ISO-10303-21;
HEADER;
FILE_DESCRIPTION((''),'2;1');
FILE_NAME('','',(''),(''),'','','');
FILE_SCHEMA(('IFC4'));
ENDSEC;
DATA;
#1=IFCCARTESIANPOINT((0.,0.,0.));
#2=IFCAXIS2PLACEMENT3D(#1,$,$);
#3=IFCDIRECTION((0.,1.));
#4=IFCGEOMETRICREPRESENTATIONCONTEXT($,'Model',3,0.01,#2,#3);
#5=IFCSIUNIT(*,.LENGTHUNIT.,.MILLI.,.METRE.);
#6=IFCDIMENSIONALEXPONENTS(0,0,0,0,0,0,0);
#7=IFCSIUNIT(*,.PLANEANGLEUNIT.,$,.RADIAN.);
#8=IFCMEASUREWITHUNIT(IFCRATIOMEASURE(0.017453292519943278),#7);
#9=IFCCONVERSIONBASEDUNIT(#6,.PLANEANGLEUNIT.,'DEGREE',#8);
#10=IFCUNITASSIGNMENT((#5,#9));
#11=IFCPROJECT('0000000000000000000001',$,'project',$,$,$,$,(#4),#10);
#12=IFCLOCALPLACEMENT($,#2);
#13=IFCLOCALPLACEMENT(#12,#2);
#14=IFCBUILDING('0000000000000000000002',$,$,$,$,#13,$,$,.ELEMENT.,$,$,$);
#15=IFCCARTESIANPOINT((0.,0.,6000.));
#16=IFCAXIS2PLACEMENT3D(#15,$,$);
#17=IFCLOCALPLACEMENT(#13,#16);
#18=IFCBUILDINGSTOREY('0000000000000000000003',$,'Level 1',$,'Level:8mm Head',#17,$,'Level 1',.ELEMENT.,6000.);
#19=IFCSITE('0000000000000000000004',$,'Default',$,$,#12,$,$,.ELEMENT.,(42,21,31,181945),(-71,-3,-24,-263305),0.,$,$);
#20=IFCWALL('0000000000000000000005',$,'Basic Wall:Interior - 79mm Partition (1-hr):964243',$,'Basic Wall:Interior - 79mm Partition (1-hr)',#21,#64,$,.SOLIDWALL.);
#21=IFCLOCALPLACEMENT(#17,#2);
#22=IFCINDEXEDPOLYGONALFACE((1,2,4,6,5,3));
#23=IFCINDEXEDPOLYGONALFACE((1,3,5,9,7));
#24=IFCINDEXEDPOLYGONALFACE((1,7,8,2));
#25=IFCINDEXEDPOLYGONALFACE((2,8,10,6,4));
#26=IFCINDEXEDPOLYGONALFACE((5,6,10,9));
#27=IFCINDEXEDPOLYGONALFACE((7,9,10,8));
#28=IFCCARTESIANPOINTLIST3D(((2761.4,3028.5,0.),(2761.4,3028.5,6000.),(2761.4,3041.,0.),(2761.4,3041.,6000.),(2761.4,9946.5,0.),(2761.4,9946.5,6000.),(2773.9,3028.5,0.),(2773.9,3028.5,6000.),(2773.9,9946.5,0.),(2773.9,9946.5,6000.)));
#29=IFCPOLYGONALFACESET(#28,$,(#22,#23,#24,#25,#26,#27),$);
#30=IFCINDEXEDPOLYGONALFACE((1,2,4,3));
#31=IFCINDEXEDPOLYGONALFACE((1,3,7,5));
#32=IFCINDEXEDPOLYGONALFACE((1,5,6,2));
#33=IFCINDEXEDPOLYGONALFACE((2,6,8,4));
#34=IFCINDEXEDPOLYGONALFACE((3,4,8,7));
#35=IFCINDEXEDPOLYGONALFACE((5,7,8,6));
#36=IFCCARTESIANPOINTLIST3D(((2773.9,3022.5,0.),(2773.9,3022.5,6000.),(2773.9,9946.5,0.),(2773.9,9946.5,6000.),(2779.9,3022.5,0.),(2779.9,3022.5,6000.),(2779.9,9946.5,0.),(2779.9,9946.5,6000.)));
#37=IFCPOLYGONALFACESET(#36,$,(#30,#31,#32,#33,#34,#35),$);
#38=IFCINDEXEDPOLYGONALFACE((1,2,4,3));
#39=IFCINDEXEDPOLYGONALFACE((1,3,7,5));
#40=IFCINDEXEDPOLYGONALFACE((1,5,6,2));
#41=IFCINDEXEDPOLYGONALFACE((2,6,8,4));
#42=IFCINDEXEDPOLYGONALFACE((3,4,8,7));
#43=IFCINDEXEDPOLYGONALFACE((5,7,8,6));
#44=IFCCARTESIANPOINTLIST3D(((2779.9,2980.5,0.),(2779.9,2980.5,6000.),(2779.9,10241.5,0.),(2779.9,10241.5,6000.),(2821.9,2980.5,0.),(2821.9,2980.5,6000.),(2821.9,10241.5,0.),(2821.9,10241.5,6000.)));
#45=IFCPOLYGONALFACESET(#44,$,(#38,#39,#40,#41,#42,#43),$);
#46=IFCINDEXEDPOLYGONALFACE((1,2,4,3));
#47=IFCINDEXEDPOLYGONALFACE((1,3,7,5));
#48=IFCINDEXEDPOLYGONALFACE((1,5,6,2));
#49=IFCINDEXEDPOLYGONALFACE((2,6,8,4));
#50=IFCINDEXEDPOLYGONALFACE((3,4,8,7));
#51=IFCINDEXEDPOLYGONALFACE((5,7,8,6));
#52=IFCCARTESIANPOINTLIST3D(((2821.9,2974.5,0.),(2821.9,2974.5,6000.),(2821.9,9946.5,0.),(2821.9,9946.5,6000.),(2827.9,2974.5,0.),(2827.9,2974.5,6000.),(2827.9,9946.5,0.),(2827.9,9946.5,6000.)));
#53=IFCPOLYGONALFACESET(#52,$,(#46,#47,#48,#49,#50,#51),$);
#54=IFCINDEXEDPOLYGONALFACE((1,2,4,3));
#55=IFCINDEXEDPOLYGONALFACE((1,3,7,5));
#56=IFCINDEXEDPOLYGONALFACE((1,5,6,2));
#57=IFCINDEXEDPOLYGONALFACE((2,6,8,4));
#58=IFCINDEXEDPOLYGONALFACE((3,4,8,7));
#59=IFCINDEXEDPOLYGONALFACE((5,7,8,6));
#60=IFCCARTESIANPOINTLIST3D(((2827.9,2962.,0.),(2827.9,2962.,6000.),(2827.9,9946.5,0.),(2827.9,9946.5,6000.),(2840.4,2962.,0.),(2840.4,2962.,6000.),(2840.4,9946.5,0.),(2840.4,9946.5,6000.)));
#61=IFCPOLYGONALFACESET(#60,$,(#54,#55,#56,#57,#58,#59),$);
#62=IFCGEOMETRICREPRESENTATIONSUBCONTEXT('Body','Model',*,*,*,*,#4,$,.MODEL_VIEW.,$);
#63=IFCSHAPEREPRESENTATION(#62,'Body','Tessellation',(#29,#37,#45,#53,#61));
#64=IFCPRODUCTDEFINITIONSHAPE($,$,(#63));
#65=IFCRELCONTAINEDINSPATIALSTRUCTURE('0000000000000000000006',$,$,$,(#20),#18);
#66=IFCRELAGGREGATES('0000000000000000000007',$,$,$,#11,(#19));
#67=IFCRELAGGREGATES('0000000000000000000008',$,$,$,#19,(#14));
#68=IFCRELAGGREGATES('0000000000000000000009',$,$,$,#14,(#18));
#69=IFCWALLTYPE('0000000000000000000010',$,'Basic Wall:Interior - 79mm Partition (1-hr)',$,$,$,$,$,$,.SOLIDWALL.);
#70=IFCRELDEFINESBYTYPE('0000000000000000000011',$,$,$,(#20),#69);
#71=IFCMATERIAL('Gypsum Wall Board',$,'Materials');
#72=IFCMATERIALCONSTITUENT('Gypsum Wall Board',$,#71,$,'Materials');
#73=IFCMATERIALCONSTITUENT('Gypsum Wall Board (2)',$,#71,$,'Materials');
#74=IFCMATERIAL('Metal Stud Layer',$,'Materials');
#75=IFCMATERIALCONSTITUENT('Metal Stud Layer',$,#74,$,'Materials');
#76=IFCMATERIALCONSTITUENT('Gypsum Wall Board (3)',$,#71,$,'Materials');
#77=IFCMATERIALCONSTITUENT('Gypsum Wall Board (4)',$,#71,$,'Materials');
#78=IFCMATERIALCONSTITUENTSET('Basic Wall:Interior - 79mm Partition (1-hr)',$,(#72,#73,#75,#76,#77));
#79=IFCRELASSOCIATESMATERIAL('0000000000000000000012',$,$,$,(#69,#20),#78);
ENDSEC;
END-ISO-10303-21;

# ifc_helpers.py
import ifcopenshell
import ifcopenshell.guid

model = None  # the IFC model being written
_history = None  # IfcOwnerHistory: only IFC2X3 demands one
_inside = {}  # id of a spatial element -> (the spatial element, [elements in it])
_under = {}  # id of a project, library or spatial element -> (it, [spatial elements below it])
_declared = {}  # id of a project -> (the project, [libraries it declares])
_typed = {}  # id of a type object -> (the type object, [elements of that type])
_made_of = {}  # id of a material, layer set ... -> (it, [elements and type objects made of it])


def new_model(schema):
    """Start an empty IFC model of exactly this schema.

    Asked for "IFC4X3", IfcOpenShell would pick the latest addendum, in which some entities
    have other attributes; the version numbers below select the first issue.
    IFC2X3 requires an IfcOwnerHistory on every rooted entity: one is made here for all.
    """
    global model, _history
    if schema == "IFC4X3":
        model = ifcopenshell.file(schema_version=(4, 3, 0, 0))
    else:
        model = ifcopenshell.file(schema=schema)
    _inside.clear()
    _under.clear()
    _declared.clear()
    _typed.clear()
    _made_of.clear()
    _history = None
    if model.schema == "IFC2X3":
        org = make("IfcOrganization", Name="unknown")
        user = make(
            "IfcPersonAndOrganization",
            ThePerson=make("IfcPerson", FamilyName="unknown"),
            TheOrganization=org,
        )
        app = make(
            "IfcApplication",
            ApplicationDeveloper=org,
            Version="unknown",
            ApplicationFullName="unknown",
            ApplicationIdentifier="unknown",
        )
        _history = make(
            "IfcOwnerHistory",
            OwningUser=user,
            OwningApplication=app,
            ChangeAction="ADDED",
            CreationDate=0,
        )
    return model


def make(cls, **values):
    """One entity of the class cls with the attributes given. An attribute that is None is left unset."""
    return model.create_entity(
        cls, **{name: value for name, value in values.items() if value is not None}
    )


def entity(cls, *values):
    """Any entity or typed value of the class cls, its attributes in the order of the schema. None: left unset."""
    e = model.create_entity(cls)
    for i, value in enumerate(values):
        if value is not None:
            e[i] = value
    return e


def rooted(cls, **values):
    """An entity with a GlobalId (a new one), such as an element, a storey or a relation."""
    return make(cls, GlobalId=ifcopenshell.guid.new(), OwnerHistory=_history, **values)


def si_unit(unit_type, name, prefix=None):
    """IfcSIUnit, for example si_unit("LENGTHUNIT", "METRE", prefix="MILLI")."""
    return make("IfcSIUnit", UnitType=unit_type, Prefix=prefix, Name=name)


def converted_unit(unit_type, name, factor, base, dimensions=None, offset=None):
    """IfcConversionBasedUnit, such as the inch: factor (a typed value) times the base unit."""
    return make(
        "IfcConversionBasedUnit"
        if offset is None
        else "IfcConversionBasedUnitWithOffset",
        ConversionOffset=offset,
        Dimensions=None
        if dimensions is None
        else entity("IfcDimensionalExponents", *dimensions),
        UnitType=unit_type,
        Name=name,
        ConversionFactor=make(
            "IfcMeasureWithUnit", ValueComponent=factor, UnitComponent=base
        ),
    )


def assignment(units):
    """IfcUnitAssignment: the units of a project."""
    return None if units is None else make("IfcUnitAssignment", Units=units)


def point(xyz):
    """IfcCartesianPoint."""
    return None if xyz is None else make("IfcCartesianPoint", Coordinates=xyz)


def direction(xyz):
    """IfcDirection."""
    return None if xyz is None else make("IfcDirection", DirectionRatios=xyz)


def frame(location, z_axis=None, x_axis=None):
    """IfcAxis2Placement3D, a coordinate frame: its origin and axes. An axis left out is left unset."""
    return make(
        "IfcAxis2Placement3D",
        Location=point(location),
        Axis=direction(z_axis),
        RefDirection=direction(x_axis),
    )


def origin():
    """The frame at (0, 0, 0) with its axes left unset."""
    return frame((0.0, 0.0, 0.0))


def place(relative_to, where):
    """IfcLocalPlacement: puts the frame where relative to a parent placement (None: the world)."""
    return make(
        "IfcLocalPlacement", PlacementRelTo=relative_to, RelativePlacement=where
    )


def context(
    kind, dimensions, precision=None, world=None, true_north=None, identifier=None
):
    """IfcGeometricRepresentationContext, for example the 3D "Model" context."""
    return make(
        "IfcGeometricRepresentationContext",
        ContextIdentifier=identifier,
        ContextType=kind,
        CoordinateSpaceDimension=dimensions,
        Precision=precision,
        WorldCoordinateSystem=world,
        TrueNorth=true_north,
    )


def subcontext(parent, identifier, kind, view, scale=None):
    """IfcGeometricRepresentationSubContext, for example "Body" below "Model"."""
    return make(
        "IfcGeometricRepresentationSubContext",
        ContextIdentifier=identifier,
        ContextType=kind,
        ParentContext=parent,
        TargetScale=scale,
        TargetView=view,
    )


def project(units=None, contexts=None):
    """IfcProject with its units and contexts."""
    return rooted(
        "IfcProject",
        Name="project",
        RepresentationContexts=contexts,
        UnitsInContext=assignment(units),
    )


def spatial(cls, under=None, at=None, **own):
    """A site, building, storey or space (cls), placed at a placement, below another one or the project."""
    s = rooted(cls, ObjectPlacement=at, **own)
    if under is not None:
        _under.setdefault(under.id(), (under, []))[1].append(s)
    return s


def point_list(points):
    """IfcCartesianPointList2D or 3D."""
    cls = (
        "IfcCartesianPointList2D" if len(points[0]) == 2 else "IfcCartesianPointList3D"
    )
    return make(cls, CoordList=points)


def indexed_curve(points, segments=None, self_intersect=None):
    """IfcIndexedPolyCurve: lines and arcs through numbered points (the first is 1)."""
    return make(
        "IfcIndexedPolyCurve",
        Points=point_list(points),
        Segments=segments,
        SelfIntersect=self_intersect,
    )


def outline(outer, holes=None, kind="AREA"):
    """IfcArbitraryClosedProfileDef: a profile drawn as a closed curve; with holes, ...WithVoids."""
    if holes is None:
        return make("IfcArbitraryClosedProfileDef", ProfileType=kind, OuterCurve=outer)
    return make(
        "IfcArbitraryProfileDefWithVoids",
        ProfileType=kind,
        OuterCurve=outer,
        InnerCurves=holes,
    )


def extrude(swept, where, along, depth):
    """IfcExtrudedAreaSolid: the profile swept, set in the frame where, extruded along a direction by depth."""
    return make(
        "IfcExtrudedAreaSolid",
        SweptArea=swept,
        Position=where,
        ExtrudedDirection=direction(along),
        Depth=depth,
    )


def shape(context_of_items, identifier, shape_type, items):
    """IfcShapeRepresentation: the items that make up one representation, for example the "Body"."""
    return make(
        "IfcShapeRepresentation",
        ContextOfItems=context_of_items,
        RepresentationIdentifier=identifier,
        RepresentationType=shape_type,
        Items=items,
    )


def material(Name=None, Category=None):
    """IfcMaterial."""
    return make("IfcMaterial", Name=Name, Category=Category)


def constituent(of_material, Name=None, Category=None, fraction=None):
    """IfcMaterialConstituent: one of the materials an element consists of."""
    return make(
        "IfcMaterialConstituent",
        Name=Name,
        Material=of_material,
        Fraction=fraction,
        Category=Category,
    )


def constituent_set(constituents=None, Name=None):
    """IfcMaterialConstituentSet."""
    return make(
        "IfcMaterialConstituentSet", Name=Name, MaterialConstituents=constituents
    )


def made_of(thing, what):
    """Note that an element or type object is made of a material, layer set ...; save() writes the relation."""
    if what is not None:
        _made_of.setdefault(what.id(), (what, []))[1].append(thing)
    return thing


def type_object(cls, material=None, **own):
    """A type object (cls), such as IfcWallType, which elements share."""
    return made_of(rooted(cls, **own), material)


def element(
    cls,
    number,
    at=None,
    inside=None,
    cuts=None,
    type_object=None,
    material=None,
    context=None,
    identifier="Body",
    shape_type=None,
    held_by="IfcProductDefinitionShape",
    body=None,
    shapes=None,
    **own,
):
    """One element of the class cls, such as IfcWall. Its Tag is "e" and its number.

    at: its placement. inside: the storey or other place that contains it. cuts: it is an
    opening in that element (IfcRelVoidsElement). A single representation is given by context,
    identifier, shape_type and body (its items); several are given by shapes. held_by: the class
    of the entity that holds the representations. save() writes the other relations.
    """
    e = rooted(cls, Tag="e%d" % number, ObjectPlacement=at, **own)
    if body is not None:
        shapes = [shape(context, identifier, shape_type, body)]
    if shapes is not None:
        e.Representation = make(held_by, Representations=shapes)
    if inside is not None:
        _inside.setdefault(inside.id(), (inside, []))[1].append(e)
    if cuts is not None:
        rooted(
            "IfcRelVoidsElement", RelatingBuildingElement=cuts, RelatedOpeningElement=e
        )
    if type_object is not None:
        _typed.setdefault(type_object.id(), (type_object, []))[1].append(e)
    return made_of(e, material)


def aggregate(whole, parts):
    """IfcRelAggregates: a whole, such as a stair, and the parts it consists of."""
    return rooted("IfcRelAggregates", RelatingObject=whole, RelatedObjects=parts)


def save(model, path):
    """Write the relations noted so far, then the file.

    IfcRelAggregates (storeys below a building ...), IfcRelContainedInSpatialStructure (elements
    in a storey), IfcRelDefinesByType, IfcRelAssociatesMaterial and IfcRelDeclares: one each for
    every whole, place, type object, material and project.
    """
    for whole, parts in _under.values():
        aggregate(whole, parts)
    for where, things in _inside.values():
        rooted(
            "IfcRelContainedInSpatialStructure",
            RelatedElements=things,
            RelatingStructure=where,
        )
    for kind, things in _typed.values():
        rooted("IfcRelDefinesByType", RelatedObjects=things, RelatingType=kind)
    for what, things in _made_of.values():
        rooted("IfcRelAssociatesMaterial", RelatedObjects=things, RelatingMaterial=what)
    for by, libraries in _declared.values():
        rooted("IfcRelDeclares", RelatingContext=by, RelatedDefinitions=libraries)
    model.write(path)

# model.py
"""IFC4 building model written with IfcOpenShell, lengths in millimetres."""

from ifc_helpers import new_model, entity, si_unit, converted_unit, direction, frame, origin, place, context, subcontext, project, spatial, indexed_curve, outline, extrude, material, constituent, constituent_set, type_object, element, save


model = new_model("IFC4")

# Units and contexts
model_context = context("Model", 3, precision=0.01, world=origin(), true_north=direction((0.0, 1.0)))
body_context = subcontext(model_context, "Body", "Model", "MODEL_VIEW")
ifc_project = project(units=[si_unit("LENGTHUNIT", "METRE", prefix="MILLI"), converted_unit("PLANEANGLEUNIT", "DEGREE", entity("IfcRatioMeasure", 0.017453292519943278), si_unit("PLANEANGLEUNIT", "RADIAN"), dimensions=[0, 0, 0, 0, 0, 0, 0])], contexts=[model_context])

# Site, building, storey
site_placement = place(None, origin())
site = spatial("IfcSite", under=ifc_project, at=site_placement, Name="Default", CompositionType="ELEMENT", RefLatitude=(42, 21, 31, 181945), RefLongitude=(-71, -3, -24, -263305), RefElevation=0.0)
building_placement = place(site_placement, origin())
building = spatial("IfcBuilding", under=site, at=building_placement, CompositionType="ELEMENT")
storey_placement = place(building_placement, frame((0.0, 0.0, 6000.0)))
storey = spatial("IfcBuildingStorey", under=building, at=storey_placement, Name="Level 1", ObjectType="Level:8mm Head", LongName="Level 1", CompositionType="ELEMENT", Elevation=6000.0)

# Wall
ifc_material_1 = material(Name="Gypsum Wall Board", Category="Materials")
ifc_constituent_1 = constituent(ifc_material_1, Name="Gypsum Wall Board", Category="Materials")
ifc_constituent_2 = constituent(ifc_material_1, Name="Gypsum Wall Board (2)", Category="Materials")
ifc_material_2 = material(Name="Metal Stud Layer", Category="Materials")
ifc_constituent_3 = constituent(ifc_material_2, Name="Metal Stud Layer", Category="Materials")
ifc_constituent_4 = constituent(ifc_material_1, Name="Gypsum Wall Board (3)", Category="Materials")
ifc_constituent_5 = constituent(ifc_material_1, Name="Gypsum Wall Board (4)", Category="Materials")
ifc_constituent_set_1 = constituent_set(constituents=[ifc_constituent_1, ifc_constituent_2, ifc_constituent_3, ifc_constituent_4, ifc_constituent_5], Name="Basic Wall:Interior - 79mm Partition (1-hr)")
wall_type = type_object("IfcWallType", Name="Basic Wall:Interior - 79mm Partition (1-hr)", PredefinedType="SOLIDWALL", material=ifc_constituent_set_1)
wall_1_placement = place(storey_placement, frame((2800.9, 9946.5, 0.0), z_axis=(0.0, 0.0, 1.0), x_axis=(0.0, -1.0, 0.0)))
element("IfcWall", 1, at=wall_1_placement, inside=storey, type_object=wall_type, material=ifc_constituent_set_1, Name="Basic Wall:Interior - 79mm Partition (1-hr):964243", ObjectType="Basic Wall:Interior - 79mm Partition (1-hr)", PredefinedType="SOLIDWALL", context=body_context, shape_type="SweptSolid", body=[
    extrude(outline(indexed_curve([(2757.2, -5.0), (2769.7, -5.0), (2769.7, 7.5), (-4148.3, 7.5), (-4148.3, -5.0), (2757.2, -5.0)], self_intersect=False)), frame((4148.3, -34.5, 0.0)), (0.0, 0.0, 1.0), 6000.0),
    extrude(outline(indexed_curve([(-3462.0, -3.0), (3462.0, -3.0), (3462.0, 3.0), (-3462.0, 3.0), (-3462.0, -3.0)], self_intersect=False)), frame((3462.0, -24.0, 0.0)), (0.0, 0.0, 1.0), 6000.0),
    extrude(outline(indexed_curve([(-3630.5, -21.0), (3630.5, -21.0), (3630.5, 21.0), (-3630.5, 21.0), (-3630.5, -21.0)], self_intersect=False)), frame((3335.5, 0.0, 0.0)), (0.0, 0.0, 1.0), 6000.0),
    extrude(outline(indexed_curve([(-3486.0, -3.0), (3486.0, -3.0), (3486.0, 3.0), (-3486.0, 3.0), (-3486.0, -3.0)], self_intersect=False)), frame((3486.0, 24.0, 0.0)), (0.0, 0.0, 1.0), 6000.0),
    extrude(outline(indexed_curve([(-6.3, -3492.3), (6.2, -3492.3), (6.3, 3492.3), (-6.2, 3492.3), (-6.3, -3492.3)], self_intersect=False)), frame((3492.3, 33.3, 0.0), z_axis=(0.0, 0.0, 1.0), x_axis=(0.0, -1.0, 0.0)), (0.0, 0.0, 1.0), 6000.0),
])

save(model, "model.ifc")
